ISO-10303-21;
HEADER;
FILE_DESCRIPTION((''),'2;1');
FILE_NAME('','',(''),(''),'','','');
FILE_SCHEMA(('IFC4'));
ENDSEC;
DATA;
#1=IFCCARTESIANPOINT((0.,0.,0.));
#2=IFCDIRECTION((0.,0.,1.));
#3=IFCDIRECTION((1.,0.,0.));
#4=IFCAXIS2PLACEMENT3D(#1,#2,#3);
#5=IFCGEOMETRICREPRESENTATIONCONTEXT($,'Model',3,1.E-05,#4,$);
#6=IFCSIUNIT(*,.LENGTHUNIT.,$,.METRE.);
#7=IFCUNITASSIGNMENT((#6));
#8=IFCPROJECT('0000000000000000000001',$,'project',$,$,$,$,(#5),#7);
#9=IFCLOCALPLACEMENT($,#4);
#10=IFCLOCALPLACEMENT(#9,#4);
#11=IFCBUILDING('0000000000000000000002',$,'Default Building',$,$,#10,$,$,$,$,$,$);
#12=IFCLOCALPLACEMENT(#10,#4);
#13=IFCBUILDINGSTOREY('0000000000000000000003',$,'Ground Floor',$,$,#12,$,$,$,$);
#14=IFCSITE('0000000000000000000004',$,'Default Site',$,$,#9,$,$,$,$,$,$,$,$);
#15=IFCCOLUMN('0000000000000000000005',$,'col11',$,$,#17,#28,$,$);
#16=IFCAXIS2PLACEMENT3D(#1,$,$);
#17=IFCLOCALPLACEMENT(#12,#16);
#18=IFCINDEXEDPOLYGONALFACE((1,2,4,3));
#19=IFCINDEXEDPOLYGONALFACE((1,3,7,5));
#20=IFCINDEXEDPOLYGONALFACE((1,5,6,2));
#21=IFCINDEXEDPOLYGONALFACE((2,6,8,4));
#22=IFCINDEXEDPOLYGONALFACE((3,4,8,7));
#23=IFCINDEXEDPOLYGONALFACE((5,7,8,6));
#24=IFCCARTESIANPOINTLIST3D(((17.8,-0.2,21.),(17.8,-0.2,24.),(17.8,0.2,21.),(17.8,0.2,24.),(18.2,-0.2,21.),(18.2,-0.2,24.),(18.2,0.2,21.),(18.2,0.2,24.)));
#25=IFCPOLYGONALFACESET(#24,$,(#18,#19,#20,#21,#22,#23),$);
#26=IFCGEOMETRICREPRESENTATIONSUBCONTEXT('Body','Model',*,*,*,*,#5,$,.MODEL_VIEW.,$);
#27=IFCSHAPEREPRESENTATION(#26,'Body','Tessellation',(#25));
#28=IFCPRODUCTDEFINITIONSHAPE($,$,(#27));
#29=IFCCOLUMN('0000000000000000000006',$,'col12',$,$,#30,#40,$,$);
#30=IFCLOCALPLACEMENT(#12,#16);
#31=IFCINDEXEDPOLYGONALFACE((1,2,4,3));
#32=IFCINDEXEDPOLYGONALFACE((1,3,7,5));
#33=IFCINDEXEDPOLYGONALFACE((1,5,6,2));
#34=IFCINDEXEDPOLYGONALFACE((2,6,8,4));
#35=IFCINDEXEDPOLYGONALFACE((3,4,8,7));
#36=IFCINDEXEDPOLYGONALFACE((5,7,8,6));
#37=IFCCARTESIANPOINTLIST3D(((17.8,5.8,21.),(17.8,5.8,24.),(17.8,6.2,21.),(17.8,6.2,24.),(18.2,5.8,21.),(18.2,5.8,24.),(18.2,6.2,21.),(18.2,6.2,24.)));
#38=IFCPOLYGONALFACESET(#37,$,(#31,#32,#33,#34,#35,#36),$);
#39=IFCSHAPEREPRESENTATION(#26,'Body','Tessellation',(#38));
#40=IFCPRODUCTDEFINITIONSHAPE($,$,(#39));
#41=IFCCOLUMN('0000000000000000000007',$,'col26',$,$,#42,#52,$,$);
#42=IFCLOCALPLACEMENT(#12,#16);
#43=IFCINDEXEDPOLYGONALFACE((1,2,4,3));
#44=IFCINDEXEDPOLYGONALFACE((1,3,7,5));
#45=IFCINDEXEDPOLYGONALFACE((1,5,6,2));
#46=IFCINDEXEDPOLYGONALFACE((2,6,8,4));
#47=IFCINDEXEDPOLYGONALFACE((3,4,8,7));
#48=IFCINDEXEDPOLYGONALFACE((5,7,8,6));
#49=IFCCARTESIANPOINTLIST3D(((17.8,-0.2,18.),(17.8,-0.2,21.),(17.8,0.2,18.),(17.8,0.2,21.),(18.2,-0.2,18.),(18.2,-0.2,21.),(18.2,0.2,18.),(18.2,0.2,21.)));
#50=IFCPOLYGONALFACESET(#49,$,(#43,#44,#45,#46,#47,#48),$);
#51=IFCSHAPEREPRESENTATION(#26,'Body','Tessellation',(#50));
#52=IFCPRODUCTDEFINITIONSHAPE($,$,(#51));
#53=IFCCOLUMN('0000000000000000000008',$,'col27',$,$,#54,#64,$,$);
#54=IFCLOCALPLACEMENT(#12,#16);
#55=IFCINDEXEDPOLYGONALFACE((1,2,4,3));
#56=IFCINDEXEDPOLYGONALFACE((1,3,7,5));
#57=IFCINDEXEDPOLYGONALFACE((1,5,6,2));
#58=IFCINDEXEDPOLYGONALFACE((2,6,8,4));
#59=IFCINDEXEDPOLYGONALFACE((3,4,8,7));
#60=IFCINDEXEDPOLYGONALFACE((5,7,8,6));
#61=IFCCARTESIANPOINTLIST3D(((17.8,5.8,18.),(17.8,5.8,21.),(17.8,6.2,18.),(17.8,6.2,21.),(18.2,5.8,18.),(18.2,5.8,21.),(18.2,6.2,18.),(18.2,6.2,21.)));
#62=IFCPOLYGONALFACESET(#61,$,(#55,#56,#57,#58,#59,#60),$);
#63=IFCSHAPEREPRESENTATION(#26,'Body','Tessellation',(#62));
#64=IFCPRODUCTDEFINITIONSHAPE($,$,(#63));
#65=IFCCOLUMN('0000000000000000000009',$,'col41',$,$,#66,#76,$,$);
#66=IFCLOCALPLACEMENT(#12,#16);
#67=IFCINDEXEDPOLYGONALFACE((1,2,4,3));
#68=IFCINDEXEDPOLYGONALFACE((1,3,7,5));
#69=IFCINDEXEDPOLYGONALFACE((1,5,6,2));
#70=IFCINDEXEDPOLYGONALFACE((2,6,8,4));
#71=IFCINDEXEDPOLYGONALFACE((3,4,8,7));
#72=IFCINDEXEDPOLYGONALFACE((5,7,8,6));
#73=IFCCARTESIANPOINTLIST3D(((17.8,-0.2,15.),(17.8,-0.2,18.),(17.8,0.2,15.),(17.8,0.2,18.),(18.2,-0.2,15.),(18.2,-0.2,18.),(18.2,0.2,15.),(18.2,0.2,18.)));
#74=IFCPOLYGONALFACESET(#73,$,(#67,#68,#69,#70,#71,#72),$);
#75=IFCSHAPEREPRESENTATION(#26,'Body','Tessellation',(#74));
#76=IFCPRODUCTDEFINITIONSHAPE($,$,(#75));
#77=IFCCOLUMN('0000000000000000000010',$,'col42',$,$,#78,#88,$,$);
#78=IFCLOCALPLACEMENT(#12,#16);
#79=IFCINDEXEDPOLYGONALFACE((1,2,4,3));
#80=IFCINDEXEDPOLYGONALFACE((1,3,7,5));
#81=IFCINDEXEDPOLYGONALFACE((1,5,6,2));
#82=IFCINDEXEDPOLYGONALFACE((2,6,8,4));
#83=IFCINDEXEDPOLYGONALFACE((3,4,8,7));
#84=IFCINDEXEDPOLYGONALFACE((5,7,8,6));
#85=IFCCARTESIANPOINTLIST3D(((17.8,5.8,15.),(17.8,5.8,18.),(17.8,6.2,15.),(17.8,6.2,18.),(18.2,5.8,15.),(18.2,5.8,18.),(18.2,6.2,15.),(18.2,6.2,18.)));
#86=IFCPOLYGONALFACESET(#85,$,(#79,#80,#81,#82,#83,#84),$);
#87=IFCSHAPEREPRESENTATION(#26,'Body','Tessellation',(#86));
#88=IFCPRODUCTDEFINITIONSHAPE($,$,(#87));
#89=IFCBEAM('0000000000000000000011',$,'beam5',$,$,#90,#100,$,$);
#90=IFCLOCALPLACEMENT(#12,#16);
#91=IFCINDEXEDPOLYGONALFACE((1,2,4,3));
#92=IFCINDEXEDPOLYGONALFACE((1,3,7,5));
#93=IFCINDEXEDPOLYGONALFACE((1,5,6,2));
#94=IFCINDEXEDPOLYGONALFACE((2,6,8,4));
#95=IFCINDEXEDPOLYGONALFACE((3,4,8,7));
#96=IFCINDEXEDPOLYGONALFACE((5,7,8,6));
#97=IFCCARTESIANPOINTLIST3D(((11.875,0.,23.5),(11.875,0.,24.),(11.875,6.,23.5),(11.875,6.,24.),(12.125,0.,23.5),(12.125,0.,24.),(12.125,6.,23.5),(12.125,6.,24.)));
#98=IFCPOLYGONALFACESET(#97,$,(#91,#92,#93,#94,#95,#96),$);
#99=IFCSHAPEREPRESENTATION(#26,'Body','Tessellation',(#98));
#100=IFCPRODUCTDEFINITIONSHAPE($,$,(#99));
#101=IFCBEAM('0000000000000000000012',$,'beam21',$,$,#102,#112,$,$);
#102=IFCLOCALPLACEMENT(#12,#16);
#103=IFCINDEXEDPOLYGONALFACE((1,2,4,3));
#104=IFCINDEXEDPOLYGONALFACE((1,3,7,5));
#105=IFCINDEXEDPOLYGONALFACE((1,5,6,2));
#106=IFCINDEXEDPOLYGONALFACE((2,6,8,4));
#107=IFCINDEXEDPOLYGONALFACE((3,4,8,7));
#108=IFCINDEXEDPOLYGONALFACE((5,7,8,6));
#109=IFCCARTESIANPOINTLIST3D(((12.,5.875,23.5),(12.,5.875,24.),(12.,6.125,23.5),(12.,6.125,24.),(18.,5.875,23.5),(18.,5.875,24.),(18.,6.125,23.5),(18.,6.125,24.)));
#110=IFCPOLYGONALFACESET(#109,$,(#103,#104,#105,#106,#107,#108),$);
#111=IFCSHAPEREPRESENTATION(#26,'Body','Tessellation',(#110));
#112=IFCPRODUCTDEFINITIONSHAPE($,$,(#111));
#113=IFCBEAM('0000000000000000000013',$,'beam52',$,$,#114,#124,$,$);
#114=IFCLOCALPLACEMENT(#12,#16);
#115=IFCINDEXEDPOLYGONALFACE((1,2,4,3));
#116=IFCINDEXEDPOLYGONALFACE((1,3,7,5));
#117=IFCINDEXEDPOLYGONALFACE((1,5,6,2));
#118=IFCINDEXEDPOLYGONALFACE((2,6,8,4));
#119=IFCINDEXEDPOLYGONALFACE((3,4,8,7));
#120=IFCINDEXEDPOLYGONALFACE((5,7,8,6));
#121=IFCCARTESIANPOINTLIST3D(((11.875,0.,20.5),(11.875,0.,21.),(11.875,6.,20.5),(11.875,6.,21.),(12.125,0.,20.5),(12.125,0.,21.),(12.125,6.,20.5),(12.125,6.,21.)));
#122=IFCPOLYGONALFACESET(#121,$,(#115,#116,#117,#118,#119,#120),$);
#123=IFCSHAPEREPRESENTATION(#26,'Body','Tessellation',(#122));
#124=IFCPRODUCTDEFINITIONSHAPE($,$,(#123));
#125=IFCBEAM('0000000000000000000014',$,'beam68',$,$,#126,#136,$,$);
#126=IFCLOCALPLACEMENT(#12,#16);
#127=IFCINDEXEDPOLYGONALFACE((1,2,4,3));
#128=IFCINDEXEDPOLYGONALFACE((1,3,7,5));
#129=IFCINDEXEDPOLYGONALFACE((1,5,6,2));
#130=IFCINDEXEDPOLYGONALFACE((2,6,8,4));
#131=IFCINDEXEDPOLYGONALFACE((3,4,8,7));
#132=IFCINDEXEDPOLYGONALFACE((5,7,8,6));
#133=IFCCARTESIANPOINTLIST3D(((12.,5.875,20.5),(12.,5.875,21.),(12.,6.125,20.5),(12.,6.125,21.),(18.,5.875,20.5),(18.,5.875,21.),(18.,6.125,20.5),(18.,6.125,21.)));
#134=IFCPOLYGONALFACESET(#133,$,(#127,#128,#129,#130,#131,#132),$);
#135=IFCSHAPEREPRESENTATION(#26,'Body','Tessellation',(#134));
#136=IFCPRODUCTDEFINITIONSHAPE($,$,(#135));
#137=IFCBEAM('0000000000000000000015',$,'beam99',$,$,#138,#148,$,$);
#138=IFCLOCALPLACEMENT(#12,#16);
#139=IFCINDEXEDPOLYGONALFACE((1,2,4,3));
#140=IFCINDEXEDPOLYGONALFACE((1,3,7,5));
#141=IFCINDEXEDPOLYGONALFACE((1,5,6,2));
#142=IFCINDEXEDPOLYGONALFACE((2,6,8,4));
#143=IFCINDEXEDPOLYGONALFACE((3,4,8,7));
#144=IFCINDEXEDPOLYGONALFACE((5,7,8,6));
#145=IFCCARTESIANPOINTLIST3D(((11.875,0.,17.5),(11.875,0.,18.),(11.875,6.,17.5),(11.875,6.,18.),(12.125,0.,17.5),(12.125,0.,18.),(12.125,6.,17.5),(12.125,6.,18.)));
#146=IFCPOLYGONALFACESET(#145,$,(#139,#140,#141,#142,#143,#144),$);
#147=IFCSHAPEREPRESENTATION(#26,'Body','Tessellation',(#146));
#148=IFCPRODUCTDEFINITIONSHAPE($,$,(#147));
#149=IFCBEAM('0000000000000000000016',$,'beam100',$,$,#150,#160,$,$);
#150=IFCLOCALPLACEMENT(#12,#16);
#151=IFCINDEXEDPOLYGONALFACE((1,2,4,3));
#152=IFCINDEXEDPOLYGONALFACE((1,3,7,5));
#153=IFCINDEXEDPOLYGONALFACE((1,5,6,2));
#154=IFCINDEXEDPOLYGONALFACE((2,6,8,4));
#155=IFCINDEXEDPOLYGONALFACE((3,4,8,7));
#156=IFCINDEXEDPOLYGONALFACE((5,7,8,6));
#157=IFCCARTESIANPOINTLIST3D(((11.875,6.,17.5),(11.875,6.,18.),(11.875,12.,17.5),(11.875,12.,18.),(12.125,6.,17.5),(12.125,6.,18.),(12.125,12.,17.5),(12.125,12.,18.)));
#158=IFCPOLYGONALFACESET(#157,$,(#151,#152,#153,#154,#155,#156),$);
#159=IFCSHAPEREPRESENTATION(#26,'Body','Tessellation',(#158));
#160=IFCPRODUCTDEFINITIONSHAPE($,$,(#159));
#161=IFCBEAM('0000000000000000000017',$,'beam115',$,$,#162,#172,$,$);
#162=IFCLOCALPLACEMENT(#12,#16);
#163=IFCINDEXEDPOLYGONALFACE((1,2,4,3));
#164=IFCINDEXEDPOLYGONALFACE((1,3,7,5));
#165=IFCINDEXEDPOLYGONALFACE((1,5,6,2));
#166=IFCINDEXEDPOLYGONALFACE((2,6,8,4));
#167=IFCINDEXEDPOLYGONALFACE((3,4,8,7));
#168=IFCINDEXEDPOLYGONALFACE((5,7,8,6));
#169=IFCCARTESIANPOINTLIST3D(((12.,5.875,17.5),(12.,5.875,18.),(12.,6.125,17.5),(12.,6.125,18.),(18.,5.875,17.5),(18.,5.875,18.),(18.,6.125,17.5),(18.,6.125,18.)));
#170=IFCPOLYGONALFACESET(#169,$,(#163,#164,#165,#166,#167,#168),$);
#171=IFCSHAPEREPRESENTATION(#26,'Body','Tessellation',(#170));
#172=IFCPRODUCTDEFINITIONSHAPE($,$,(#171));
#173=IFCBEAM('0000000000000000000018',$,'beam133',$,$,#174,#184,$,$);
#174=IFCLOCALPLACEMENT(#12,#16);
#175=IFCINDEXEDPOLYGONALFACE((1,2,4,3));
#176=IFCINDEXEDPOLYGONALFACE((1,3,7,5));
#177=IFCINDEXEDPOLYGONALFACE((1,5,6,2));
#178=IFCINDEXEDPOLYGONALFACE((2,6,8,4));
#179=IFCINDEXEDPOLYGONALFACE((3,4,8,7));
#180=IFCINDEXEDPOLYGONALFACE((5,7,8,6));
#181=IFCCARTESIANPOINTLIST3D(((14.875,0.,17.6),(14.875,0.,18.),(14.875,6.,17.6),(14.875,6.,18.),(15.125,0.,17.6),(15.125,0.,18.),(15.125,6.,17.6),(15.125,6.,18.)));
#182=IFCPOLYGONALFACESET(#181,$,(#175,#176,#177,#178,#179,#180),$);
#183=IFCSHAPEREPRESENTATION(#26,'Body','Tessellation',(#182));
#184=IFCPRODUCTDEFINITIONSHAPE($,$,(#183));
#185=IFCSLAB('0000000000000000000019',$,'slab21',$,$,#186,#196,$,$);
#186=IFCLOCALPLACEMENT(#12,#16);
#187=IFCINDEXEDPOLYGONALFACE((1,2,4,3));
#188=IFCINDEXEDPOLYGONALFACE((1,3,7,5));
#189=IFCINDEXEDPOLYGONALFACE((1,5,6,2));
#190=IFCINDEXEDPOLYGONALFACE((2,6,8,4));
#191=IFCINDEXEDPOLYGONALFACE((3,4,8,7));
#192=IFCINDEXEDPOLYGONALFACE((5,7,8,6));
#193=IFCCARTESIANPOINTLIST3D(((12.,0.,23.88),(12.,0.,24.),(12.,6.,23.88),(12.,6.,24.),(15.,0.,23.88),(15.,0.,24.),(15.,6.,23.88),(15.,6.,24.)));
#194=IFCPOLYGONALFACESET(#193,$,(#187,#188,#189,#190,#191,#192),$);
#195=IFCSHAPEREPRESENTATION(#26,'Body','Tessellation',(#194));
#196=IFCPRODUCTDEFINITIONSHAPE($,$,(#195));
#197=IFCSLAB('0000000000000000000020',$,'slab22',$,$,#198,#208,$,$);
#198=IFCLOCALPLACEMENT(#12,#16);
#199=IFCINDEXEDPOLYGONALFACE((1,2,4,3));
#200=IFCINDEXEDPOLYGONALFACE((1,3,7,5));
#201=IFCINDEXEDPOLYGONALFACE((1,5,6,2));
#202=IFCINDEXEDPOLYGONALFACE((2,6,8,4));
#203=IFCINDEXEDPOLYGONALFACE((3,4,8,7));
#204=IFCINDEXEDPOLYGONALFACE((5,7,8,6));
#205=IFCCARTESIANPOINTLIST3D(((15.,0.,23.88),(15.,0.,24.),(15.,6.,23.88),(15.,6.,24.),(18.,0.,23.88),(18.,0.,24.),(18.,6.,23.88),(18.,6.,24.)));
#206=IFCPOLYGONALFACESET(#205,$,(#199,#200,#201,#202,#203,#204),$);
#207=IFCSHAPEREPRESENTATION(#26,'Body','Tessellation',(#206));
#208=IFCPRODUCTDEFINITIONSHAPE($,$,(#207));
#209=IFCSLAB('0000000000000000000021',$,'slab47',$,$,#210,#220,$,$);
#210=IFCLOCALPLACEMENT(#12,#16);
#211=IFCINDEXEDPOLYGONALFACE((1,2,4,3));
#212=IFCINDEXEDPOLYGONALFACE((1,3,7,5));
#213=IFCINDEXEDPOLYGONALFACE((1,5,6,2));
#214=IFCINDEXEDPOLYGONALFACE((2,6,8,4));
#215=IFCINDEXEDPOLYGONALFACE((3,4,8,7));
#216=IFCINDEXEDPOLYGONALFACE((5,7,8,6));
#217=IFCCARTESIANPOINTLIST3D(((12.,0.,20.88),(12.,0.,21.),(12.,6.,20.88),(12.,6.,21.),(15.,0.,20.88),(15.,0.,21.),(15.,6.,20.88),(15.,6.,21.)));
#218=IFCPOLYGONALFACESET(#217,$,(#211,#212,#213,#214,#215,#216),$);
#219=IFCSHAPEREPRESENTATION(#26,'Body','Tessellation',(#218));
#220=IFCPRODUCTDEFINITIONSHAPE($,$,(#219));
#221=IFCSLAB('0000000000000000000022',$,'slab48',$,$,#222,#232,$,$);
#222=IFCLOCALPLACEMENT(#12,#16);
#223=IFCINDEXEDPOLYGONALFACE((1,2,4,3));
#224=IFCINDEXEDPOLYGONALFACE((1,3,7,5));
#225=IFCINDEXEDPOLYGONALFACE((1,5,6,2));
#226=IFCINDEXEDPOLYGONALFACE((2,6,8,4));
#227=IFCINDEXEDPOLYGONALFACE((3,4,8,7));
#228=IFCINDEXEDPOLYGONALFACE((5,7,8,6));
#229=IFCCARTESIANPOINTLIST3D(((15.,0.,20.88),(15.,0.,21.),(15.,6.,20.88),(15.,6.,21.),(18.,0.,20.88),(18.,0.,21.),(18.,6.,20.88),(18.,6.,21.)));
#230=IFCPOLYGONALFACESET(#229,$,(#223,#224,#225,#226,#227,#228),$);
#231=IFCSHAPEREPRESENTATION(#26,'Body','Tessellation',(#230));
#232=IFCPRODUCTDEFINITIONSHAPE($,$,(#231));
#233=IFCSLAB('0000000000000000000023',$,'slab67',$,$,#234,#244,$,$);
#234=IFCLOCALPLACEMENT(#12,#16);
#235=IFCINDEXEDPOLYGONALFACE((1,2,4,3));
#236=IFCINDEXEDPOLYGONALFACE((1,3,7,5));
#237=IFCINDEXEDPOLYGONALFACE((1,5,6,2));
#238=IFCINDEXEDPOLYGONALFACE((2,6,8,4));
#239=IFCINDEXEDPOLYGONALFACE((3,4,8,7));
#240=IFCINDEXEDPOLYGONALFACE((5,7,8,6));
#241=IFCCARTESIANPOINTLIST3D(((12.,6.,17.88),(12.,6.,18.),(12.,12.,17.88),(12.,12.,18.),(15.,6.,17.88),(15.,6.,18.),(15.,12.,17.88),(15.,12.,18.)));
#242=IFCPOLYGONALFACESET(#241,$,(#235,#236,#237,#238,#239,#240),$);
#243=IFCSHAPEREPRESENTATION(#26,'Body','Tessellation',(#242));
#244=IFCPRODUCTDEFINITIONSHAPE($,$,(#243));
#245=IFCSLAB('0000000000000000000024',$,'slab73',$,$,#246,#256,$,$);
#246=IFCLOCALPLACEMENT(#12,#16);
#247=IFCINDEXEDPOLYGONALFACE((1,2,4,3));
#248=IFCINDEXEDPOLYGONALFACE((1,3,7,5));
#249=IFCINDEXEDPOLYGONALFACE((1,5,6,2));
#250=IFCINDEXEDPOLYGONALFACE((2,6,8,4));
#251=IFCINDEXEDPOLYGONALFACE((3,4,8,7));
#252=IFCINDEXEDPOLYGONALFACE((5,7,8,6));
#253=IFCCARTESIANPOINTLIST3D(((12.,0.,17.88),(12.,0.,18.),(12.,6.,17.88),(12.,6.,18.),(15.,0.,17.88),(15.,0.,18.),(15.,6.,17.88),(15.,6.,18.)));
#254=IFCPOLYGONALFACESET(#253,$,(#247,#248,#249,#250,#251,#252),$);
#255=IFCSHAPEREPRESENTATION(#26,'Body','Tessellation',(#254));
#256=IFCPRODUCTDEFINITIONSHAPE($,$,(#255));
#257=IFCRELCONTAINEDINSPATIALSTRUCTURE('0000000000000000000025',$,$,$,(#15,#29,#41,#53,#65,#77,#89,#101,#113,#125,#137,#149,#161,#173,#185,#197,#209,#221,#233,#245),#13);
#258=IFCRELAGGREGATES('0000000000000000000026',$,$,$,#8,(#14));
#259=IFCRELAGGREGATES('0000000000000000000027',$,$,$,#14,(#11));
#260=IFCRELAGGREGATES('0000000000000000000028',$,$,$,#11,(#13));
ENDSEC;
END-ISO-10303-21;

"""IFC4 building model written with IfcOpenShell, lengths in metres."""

from ifc_helpers import new_model, si_unit, frame, origin_with_axes, place, context, subcontext, project, spatial, indexed_curve, outline, extrude, element, save


model = new_model("IFC4")

# Units and contexts
model_context = context("Model", 3, precision=1e-05, world=origin_with_axes())
body_context = subcontext(model_context, "Body", "Model", "MODEL_VIEW")
ifc_project = project(units=[si_unit("LENGTHUNIT", "METRE")], contexts=[model_context])

# Site, building, storey
site_placement = place(None, origin_with_axes())
site = spatial("IfcSite", under=ifc_project, at=site_placement, Name="Default Site")
building_placement = place(site_placement, origin_with_axes())
building = spatial("IfcBuilding", under=site, at=building_placement, Name="Default Building")
storey_placement = place(building_placement, origin_with_axes())
storey = spatial("IfcBuildingStorey", under=building, at=storey_placement, Name="Ground Floor")

# Columns
for number, where, z_axis, x_axis, name in (
    (1, (17.8, -0.2, 21.0), (0.0, 0.0, 1.0), (1.0, 0.0, 0.0), "col11"),
    (2, (17.8, 5.8, 21.0), (0.0, 0.0, 1.0), (1.0, 0.0, 0.0), "col12"),
    (3, (17.8, -0.2, 18.0), (0.0, 0.0, 1.0), (1.0, 0.0, 0.0), "col26"),
    (4, (17.8, 5.8, 18.0), (0.0, 0.0, 1.0), (1.0, 0.0, 0.0), "col27"),
    (5, (17.8, -0.2, 15.0), (0.0, 0.0, 1.0), (1.0, 0.0, 0.0), "col41"),
    (6, (17.8, 5.8, 15.0), (0.0, 0.0, 1.0), (1.0, 0.0, 0.0), "col42"),
):
    element("IfcColumn", number, at=place(storey_placement, frame(where, z_axis=z_axis, x_axis=x_axis)), inside=storey, Name=name, context=body_context, shape_type="SweptSolid", body=[
        extrude(outline(indexed_curve([(0.0, 0.0), (0.0, 0.4), (0.4, 0.4), (0.4, 0.0), (0.0, 0.0)], self_intersect=False)), origin_with_axes(), (0.0, 0.0, 1.0), 3.0),
    ])

# Beams
for number, where, z_axis, x_axis, name in (
    (7, (12.125, 0.0, 23.5), (0.0, 0.0, 1.0), (0.0, 1.0, 0.0), "beam5"),
    (8, (12.0, 5.875, 23.5), (0.0, 0.0, 1.0), (1.0, 0.0, 0.0), "beam21"),
    (9, (12.125, 0.0, 20.5), (0.0, 0.0, 1.0), (0.0, 1.0, 0.0), "beam52"),
    (10, (12.0, 5.875, 20.5), (0.0, 0.0, 1.0), (1.0, 0.0, 0.0), "beam68"),
    (11, (12.125, 0.0, 17.5), (0.0, 0.0, 1.0), (0.0, 1.0, 0.0), "beam99"),
    (12, (12.125, 6.0, 17.5), (0.0, 0.0, 1.0), (0.0, 1.0, 0.0), "beam100"),
    (13, (12.0, 5.875, 17.5), (0.0, 0.0, 1.0), (1.0, 0.0, 0.0), "beam115"),
):
    element("IfcBeam", number, at=place(storey_placement, frame(where, z_axis=z_axis, x_axis=x_axis)), inside=storey, Name=name, context=body_context, shape_type="SweptSolid", body=[
        extrude(outline(indexed_curve([(0.0, 0.0), (0.0, 0.25), (6.0, 0.25), (6.0, 0.0), (0.0, 0.0)], self_intersect=False)), origin_with_axes(), (0.0, 0.0, 1.0), 0.5),
    ])
beam_placement = place(storey_placement, frame((14.875, 6.0, 17.6), z_axis=(0.0, 0.0, 1.0), x_axis=(0.0, -1.0, 0.0)))
element("IfcBeam", 14, at=beam_placement, inside=storey, Name="beam133", context=body_context, shape_type="SweptSolid", body=[
    extrude(outline(indexed_curve([(0.0, 0.0), (0.0, 0.25), (6.0, 0.25), (6.0, 0.0), (0.0, 0.0)], self_intersect=False)), origin_with_axes(), (0.0, 0.0, 1.0), 0.4),
])

# Slabs
for number, where, z_axis, x_axis, name in (
    (15, (12.0, 0.0, 23.88), (0.0, 0.0, 1.0), (1.0, 0.0, 0.0), "slab21"),
    (16, (15.0, 0.0, 23.88), (0.0, 0.0, 1.0), (1.0, 0.0, 0.0), "slab22"),
    (17, (12.0, 0.0, 20.88), (0.0, 0.0, 1.0), (1.0, 0.0, 0.0), "slab47"),
    (18, (15.0, 0.0, 20.88), (0.0, 0.0, 1.0), (1.0, 0.0, 0.0), "slab48"),
    (19, (12.0, 6.0, 17.88), (0.0, 0.0, 1.0), (1.0, 0.0, 0.0), "slab67"),
    (20, (12.0, 0.0, 17.88), (0.0, 0.0, 1.0), (1.0, 0.0, 0.0), "slab73"),
):
    element("IfcSlab", number, at=place(storey_placement, frame(where, z_axis=z_axis, x_axis=x_axis)), inside=storey, Name=name, context=body_context, shape_type="SweptSolid", body=[
        extrude(outline(indexed_curve([(0.0, 0.0), (0.0, 6.0), (3.0, 6.0), (3.0, 0.0), (0.0, 0.0)], self_intersect=False)), origin_with_axes(), (0.0, 0.0, 1.0), 0.12),
    ])

save(model, "model.ifc")
